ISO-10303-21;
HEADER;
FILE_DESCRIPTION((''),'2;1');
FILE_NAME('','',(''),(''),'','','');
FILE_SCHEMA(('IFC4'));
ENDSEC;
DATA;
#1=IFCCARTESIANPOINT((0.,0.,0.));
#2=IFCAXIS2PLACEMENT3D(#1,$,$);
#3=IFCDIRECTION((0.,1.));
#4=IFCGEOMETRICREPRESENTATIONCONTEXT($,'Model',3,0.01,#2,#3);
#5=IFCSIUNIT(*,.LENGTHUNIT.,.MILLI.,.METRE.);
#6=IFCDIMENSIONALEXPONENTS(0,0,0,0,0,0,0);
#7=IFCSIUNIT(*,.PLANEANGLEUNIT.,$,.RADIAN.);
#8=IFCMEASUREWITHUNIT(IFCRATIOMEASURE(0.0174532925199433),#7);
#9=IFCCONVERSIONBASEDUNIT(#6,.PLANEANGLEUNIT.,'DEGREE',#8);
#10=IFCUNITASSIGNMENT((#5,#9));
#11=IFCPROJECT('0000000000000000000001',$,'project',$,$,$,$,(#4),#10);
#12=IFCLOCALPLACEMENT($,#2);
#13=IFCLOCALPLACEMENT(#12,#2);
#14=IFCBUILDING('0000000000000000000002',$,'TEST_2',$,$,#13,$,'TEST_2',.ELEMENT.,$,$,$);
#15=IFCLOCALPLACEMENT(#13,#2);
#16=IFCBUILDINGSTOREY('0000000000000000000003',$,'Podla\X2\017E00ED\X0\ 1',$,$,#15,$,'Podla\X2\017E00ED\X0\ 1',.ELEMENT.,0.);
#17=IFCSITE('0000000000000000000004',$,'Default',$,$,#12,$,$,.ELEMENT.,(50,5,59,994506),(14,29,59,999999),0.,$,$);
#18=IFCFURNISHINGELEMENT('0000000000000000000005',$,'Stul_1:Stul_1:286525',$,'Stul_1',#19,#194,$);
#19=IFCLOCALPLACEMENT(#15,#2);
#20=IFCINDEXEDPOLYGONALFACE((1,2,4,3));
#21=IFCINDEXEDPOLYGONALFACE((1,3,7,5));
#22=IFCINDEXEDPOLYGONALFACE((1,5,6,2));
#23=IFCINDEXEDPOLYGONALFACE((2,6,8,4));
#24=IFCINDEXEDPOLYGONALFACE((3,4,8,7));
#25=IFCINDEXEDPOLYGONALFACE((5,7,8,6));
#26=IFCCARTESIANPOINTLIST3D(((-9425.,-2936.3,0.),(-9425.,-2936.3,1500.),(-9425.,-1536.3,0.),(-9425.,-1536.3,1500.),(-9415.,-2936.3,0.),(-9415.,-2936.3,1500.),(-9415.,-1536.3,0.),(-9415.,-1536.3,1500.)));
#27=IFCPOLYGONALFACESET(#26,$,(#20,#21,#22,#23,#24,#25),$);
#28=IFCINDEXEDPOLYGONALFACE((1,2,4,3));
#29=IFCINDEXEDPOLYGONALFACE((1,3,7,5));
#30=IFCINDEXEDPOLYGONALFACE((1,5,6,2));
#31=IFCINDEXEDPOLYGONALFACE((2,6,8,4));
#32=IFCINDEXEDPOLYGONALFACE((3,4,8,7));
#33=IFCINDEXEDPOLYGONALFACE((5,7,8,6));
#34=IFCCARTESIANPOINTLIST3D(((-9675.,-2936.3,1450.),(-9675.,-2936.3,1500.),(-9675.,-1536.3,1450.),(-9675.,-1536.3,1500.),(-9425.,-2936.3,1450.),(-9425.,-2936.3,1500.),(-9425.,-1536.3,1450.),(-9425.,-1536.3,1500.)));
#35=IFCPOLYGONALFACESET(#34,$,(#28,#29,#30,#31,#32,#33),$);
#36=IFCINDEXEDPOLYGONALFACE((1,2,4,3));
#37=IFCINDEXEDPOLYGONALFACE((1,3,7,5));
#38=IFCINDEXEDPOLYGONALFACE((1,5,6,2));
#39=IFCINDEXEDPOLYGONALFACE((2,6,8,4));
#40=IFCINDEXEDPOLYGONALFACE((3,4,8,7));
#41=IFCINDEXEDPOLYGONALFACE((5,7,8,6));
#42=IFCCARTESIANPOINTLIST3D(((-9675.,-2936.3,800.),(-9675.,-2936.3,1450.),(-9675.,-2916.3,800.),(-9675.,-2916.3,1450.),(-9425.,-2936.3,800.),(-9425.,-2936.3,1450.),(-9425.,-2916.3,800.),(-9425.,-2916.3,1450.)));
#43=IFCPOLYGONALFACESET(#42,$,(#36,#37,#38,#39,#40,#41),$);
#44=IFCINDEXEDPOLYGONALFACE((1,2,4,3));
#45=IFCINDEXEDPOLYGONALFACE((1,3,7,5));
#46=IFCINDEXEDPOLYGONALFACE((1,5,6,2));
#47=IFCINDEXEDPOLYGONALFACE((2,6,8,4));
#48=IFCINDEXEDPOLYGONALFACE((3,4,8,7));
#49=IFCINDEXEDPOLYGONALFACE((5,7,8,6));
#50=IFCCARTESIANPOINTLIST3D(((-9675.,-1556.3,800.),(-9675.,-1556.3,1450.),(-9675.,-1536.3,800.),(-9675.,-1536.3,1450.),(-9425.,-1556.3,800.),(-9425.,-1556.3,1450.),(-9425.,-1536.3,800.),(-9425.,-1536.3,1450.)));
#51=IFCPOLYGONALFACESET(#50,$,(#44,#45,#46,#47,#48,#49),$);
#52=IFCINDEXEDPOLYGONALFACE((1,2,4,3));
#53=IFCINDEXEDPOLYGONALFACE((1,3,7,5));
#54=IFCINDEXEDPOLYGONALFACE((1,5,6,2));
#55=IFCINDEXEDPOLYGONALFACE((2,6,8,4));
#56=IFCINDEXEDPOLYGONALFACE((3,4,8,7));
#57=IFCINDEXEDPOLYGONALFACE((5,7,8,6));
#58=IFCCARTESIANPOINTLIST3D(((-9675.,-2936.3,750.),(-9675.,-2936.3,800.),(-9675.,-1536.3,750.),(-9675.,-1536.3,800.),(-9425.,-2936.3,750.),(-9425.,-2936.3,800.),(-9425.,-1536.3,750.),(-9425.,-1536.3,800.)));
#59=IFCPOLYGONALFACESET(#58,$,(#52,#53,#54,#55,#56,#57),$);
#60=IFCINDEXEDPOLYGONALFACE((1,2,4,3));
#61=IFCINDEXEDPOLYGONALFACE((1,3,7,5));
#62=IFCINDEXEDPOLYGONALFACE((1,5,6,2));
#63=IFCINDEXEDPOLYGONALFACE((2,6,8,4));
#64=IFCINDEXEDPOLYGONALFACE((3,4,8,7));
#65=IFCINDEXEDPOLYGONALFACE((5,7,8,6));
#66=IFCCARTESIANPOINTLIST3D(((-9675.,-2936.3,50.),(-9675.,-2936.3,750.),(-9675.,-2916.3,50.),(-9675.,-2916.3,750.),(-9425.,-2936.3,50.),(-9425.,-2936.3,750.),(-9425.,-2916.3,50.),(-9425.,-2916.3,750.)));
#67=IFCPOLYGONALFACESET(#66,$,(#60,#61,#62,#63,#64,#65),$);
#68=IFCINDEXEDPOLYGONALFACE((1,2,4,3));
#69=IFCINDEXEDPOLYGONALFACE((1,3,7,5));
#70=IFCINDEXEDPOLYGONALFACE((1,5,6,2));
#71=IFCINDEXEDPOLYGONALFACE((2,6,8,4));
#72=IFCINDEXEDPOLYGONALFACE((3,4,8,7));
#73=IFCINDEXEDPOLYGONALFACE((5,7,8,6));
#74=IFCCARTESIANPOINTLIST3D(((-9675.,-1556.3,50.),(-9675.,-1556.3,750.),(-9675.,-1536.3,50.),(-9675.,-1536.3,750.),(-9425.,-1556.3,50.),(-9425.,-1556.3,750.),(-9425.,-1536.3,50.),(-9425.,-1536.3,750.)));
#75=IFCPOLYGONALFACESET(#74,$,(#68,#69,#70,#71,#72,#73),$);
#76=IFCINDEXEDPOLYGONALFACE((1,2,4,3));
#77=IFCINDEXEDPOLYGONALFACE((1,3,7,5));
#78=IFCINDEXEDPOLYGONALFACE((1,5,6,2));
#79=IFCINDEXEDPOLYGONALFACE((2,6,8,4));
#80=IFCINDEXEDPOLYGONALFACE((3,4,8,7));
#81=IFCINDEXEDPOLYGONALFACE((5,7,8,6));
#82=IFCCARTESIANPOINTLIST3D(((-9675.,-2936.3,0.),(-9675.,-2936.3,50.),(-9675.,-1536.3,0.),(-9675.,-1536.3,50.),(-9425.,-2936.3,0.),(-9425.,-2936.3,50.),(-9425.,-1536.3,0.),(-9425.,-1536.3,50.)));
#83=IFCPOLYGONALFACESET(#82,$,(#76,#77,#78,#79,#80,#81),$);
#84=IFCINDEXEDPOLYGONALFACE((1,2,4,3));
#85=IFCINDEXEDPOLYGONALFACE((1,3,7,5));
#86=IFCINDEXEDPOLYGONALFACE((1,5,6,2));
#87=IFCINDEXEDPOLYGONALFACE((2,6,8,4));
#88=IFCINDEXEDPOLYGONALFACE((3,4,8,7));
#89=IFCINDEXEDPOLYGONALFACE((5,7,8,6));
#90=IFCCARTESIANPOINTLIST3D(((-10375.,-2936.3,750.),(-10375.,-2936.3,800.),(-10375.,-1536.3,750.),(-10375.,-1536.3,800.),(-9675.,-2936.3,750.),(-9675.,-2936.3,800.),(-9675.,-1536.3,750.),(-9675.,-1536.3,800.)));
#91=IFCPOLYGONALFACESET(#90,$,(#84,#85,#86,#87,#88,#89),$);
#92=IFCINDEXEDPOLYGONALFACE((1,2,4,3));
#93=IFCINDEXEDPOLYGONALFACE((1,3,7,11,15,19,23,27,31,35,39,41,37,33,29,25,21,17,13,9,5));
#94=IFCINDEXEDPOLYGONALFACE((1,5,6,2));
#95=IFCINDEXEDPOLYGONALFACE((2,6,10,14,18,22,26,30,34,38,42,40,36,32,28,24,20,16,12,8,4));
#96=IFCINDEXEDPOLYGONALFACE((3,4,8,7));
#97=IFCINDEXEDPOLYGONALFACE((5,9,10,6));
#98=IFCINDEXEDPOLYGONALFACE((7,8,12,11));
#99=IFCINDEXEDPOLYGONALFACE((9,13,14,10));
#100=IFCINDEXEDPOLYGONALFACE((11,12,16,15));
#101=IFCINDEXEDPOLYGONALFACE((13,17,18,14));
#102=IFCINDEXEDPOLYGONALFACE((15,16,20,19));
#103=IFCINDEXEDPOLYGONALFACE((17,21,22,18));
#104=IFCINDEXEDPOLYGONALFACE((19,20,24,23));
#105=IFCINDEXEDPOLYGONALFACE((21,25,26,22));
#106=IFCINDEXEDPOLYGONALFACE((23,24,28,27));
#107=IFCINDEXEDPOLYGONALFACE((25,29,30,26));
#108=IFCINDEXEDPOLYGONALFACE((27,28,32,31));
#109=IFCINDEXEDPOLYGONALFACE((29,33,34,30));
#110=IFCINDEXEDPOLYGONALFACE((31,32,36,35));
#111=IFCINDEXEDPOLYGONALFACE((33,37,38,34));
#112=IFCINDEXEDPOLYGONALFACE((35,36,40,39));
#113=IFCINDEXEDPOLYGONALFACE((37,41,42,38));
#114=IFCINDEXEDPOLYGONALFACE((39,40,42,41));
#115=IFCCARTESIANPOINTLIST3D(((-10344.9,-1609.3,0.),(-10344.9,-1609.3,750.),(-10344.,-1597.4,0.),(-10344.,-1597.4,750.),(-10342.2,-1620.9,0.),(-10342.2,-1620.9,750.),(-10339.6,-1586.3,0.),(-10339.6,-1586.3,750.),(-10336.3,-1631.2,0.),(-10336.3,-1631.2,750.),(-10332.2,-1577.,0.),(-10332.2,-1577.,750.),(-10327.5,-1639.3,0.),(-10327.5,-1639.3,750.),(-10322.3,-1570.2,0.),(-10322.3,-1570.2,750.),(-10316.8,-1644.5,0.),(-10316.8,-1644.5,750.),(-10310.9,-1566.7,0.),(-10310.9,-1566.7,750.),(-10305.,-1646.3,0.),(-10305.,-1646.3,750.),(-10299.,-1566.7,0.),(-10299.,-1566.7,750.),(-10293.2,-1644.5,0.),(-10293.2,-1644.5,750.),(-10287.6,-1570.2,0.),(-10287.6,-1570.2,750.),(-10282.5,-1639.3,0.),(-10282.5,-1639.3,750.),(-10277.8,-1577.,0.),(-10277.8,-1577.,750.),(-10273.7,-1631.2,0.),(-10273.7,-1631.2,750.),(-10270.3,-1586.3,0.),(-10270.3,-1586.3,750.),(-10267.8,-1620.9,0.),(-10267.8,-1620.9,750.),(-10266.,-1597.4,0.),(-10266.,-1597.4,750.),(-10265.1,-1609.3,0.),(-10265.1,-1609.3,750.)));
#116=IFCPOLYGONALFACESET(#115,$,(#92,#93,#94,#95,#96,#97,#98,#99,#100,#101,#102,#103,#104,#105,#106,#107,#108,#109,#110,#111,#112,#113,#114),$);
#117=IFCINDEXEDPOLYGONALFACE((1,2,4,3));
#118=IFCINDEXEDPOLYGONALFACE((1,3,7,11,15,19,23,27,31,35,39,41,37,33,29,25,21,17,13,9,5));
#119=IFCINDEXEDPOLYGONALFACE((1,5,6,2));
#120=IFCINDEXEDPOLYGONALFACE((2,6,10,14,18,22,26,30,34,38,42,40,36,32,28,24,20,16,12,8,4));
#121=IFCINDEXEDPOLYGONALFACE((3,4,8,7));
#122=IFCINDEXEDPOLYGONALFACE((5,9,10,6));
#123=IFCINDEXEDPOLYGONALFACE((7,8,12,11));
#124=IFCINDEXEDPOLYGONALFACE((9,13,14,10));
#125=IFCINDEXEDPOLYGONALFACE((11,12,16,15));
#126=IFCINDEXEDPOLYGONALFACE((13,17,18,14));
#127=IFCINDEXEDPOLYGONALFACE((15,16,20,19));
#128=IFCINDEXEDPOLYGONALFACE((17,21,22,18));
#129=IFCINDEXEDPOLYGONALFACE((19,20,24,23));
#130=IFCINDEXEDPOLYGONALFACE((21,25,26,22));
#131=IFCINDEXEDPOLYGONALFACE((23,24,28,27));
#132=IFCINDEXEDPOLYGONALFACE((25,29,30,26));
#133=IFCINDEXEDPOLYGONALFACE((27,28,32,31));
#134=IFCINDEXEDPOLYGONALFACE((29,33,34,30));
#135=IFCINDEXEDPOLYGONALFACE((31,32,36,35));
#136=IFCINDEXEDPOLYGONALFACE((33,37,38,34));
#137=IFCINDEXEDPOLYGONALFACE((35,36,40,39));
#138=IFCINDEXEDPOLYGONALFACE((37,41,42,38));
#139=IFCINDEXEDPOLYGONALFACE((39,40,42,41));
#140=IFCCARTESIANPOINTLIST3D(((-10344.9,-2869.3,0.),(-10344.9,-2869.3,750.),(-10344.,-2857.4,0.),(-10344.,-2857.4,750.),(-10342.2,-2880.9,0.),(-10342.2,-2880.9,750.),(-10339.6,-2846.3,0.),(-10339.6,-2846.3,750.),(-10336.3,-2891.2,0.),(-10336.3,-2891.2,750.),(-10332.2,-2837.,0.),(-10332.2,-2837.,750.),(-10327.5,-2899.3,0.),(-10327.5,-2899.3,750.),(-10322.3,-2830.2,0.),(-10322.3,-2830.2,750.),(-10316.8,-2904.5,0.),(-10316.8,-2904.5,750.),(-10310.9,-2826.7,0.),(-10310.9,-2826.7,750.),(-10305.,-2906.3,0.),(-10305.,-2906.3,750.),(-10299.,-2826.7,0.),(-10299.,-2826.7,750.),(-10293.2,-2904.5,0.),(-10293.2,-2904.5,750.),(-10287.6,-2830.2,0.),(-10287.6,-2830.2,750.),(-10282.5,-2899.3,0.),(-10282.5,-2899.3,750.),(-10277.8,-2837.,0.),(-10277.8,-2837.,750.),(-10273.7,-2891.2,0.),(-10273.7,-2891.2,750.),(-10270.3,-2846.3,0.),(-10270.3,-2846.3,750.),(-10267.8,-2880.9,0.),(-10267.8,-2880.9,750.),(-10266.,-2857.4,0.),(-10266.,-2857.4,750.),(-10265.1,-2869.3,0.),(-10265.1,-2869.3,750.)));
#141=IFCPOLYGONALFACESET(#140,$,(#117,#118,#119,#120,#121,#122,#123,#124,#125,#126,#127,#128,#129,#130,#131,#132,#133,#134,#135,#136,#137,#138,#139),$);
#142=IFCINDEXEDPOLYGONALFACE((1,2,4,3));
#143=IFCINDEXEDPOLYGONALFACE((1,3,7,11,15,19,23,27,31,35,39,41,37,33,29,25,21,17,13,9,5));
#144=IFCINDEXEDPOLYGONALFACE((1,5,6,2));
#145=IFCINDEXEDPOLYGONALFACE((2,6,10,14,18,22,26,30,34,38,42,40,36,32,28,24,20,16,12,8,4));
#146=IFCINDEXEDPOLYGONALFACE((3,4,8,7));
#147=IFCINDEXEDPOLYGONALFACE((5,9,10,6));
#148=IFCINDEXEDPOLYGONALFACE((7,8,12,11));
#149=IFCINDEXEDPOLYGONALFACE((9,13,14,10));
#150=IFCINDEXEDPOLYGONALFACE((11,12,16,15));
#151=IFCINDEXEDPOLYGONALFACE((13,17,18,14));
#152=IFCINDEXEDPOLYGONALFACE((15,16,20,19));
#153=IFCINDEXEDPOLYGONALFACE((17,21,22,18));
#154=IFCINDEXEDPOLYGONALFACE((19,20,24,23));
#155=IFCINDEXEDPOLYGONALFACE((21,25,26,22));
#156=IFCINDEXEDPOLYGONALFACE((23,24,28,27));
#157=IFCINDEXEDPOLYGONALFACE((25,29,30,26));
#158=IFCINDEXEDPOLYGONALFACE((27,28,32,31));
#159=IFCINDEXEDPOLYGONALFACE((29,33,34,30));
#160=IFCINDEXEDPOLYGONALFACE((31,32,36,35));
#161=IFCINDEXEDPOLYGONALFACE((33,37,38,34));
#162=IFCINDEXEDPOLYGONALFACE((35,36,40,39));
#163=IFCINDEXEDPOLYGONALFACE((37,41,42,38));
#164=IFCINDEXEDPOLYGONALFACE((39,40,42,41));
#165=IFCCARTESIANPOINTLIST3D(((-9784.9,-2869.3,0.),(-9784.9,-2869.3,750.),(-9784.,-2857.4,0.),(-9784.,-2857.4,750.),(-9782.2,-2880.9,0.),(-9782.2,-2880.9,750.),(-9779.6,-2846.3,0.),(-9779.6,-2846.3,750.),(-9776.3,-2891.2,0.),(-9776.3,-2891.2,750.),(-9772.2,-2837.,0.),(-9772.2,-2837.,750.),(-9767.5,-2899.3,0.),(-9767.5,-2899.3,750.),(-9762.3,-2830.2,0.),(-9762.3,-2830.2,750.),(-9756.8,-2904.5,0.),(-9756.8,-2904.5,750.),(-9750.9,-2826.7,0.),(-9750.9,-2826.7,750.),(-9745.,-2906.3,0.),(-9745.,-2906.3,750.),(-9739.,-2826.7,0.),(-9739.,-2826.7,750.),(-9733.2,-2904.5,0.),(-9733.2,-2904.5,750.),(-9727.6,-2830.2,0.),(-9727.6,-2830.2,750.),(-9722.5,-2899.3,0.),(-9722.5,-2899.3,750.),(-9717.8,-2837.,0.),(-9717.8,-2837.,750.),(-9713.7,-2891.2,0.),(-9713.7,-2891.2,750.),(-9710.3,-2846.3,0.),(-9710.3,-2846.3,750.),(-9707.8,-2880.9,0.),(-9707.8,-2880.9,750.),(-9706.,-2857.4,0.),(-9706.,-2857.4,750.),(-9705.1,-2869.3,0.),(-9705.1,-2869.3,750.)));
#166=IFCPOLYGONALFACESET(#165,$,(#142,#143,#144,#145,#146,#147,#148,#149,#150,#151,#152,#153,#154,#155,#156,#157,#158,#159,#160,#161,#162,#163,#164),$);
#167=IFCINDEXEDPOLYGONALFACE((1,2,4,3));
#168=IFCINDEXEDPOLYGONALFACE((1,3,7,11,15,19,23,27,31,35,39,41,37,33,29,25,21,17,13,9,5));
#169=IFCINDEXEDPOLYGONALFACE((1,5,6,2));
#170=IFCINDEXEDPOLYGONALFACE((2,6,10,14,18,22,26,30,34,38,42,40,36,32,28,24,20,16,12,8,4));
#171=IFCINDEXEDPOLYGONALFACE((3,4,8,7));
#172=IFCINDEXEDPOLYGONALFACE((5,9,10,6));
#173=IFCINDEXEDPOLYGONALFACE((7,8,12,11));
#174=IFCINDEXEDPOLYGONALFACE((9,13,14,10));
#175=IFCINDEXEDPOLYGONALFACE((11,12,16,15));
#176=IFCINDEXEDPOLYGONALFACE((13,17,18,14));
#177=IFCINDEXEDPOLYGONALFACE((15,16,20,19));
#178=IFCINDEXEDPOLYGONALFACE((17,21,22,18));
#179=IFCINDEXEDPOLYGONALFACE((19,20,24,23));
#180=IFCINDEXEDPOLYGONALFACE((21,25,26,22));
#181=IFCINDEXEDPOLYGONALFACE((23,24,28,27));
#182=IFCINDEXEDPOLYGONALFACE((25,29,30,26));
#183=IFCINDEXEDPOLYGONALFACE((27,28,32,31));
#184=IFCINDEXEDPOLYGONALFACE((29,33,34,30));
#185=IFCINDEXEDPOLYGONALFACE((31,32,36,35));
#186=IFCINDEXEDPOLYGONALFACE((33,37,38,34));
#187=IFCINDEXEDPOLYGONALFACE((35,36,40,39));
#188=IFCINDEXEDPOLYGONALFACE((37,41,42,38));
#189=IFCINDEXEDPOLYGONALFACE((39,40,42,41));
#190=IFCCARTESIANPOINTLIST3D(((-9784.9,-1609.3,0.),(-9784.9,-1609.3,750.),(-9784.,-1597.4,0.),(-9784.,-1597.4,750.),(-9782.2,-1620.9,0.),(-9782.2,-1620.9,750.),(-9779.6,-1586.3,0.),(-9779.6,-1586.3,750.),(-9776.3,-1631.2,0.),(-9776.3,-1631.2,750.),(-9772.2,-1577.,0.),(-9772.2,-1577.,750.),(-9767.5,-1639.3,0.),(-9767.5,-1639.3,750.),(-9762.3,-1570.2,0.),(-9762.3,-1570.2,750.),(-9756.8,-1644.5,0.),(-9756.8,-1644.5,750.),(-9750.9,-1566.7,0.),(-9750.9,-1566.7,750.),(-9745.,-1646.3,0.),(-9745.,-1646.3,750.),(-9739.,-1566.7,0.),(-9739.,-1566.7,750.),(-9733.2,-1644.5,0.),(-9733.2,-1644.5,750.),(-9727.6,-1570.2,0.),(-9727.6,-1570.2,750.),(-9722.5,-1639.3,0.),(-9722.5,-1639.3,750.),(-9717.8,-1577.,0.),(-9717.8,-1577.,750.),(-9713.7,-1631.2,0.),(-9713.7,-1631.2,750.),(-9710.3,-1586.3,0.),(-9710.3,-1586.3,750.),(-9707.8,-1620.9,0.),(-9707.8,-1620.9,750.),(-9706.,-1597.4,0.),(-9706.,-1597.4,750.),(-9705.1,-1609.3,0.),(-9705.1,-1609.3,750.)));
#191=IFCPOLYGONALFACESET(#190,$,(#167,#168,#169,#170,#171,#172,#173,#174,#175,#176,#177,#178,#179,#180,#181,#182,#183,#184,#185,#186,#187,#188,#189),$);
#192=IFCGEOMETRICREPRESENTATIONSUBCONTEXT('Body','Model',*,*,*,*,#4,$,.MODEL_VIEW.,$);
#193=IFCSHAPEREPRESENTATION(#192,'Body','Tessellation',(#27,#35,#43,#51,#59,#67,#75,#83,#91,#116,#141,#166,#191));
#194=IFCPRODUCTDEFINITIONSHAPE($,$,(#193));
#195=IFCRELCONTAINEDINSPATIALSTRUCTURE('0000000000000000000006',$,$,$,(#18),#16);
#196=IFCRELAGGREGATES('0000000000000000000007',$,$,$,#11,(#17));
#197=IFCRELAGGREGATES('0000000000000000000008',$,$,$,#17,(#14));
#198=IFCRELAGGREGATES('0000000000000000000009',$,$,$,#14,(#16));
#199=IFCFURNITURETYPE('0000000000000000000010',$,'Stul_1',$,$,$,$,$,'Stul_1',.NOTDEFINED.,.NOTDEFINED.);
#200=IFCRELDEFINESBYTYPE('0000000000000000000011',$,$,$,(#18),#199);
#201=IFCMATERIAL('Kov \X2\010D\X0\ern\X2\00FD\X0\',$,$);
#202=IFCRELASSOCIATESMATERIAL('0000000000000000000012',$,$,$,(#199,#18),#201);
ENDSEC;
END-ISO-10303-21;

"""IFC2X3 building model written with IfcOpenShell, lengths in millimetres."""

from ifc_helpers import new_model, entity, si_unit, converted_unit, direction, frame, frame_2d, origin, origin_2d_with_axis, place, context, subcontext, project, spatial, rectangle, circle, extrude, source, transform, mapped, material, type_object, type_shapes, element, save


model = new_model("IFC2X3")

# Units and contexts
model_context = context("Model", 3, precision=0.01, world=origin(), true_north=direction((0.0, 1.0)))
body_context = subcontext(model_context, "Body", "Model", "MODEL_VIEW")
ifc_project = project(units=[si_unit("LENGTHUNIT", "METRE", prefix="MILLI"), converted_unit("PLANEANGLEUNIT", "DEGREE", entity("IfcRatioMeasure", 0.0174532925199433), si_unit("PLANEANGLEUNIT", "RADIAN"), dimensions=[0, 0, 0, 0, 0, 0, 0])], contexts=[model_context])

# Site, building, storey
site_placement = place(None, origin())
site = spatial("IfcSite", under=ifc_project, at=site_placement, Name="Default", CompositionType="ELEMENT", RefLatitude=(50, 5, 59, 994506), RefLongitude=(14, 29, 59, 999999), RefElevation=0.0)
building_placement = place(site_placement, origin())
building = spatial("IfcBuilding", under=site, at=building_placement, Name="TEST_2", LongName="TEST_2", CompositionType="ELEMENT")
storey_placement = place(building_placement, origin())
storey = spatial("IfcBuildingStorey", under=building, at=storey_placement, Name="Podlaží 1", LongName="Podlaží 1", CompositionType="ELEMENT", Elevation=0.0)

# Furnishing element
ifc_material_1 = material(Name="Kov černý")
furniture_type = type_object("IfcFurnitureType", Name="Stul_1", ElementType="Stul_1", material=ifc_material_1)
shared_shape_1 = source(origin(), body_context, "Body", "SweptSolid", [
    extrude(rectangle(XDim=1400.0, YDim=10.0, at=origin_2d_with_axis()), frame((0.0, 605.0, 0.0), z_axis=(0.0, 0.0, 1.0), x_axis=(-1.0, 0.0, 0.0)), (0.0, 0.0, 1.0), 1500.0),
    extrude(rectangle(XDim=1400.0, YDim=250.0, at=frame_2d((0.0, 0.0), x_axis=(1.0, 0.0))), frame((0.0, 475.0, 1450.0), z_axis=(0.0, 0.0, 1.0), x_axis=(-1.0, 0.0, 0.0)), (0.0, 0.0, 1.0), 50.0),
    extrude(rectangle(XDim=20.0, YDim=250.0, at=origin_2d_with_axis()), frame((690.0, 475.0, 800.0), z_axis=(0.0, 0.0, 1.0), x_axis=(-1.0, 0.0, 0.0)), (0.0, 0.0, 1.0), 650.0),
    extrude(rectangle(XDim=20.0, YDim=250.0, at=frame_2d((0.0, 0.0), x_axis=(1.0, 0.0))), frame((-690.0, 475.0, 800.0), z_axis=(0.0, 0.0, 1.0), x_axis=(-1.0, 0.0, 0.0)), (0.0, 0.0, 1.0), 650.0),
    extrude(rectangle(XDim=1400.0, YDim=250.0, at=origin_2d_with_axis()), frame((0.0, 475.0, 750.0), z_axis=(0.0, 0.0, 1.0), x_axis=(-1.0, 0.0, 0.0)), (0.0, 0.0, 1.0), 50.0),
    extrude(rectangle(XDim=20.0, YDim=250.0, at=origin_2d_with_axis()), frame((690.0, 475.0, 50.0), z_axis=(0.0, 0.0, 1.0), x_axis=(-1.0, 0.0, 0.0)), (0.0, 0.0, 1.0), 700.0),
    extrude(rectangle(XDim=20.0, YDim=250.0, at=frame_2d((0.0, 0.0), x_axis=(1.0, 0.0))), frame((-690.0, 475.0, 50.0), z_axis=(0.0, 0.0, 1.0), x_axis=(-1.0, 0.0, 0.0)), (0.0, 0.0, 1.0), 700.0),
    extrude(rectangle(XDim=1400.0, YDim=250.0, at=origin_2d_with_axis()), frame((0.0, 475.0, 0.0), z_axis=(0.0, 0.0, 1.0), x_axis=(-1.0, 0.0, 0.0)), (0.0, 0.0, 1.0), 50.0),
    extrude(rectangle(XDim=1400.0, YDim=700.0, at=origin_2d_with_axis()), frame((0.0, 0.0, 750.0), z_axis=(0.0, 0.0, 1.0), x_axis=(-1.0, 0.0, 0.0)), (0.0, 0.0, 1.0), 50.0),
    extrude(circle(Radius=40.0, at=frame_2d((0.0, 0.0), x_axis=(1.0, 0.0))), frame((-630.0, -280.0, 0.0)), (0.0, 0.0, 1.0), 750.0),
    extrude(circle(Radius=40.0, at=frame_2d((0.0, 0.0), x_axis=(1.0, 0.0))), frame((630.0, -280.0, 0.0)), (0.0, 0.0, 1.0), 750.0),
    extrude(circle(Radius=40.0, at=frame_2d((0.0, 0.0), x_axis=(1.0, 0.0))), frame((630.0, 280.0, 0.0)), (0.0, 0.0, 1.0), 750.0),
    extrude(circle(Radius=40.0, at=frame_2d((0.0, 0.0), x_axis=(1.0, 0.0))), frame((-630.0, 280.0, 0.0)), (0.0, 0.0, 1.0), 750.0),
])
type_shapes(furniture_type, [shared_shape_1])
for number, where, z_axis, x_axis, name in (
    (1, (-10025.0, -2236.3, 0.0), (0.0, 0.0, 1.0), (0.0, -1.0, 0.0), "Stul_1:Stul_1:286525"),
):
    element("IfcFurnishingElement", number, at=place(storey_placement, frame(where, z_axis=z_axis, x_axis=x_axis)), inside=storey, type_object=furniture_type, material=ifc_material_1, Name=name, ObjectType="Stul_1", context=body_context, shape_type="MappedRepresentation", body=[
        mapped(shared_shape_1, transform((0.0, 0.0, 0.0), scale=1.0)),
    ])

save(model, "model.ifc")
